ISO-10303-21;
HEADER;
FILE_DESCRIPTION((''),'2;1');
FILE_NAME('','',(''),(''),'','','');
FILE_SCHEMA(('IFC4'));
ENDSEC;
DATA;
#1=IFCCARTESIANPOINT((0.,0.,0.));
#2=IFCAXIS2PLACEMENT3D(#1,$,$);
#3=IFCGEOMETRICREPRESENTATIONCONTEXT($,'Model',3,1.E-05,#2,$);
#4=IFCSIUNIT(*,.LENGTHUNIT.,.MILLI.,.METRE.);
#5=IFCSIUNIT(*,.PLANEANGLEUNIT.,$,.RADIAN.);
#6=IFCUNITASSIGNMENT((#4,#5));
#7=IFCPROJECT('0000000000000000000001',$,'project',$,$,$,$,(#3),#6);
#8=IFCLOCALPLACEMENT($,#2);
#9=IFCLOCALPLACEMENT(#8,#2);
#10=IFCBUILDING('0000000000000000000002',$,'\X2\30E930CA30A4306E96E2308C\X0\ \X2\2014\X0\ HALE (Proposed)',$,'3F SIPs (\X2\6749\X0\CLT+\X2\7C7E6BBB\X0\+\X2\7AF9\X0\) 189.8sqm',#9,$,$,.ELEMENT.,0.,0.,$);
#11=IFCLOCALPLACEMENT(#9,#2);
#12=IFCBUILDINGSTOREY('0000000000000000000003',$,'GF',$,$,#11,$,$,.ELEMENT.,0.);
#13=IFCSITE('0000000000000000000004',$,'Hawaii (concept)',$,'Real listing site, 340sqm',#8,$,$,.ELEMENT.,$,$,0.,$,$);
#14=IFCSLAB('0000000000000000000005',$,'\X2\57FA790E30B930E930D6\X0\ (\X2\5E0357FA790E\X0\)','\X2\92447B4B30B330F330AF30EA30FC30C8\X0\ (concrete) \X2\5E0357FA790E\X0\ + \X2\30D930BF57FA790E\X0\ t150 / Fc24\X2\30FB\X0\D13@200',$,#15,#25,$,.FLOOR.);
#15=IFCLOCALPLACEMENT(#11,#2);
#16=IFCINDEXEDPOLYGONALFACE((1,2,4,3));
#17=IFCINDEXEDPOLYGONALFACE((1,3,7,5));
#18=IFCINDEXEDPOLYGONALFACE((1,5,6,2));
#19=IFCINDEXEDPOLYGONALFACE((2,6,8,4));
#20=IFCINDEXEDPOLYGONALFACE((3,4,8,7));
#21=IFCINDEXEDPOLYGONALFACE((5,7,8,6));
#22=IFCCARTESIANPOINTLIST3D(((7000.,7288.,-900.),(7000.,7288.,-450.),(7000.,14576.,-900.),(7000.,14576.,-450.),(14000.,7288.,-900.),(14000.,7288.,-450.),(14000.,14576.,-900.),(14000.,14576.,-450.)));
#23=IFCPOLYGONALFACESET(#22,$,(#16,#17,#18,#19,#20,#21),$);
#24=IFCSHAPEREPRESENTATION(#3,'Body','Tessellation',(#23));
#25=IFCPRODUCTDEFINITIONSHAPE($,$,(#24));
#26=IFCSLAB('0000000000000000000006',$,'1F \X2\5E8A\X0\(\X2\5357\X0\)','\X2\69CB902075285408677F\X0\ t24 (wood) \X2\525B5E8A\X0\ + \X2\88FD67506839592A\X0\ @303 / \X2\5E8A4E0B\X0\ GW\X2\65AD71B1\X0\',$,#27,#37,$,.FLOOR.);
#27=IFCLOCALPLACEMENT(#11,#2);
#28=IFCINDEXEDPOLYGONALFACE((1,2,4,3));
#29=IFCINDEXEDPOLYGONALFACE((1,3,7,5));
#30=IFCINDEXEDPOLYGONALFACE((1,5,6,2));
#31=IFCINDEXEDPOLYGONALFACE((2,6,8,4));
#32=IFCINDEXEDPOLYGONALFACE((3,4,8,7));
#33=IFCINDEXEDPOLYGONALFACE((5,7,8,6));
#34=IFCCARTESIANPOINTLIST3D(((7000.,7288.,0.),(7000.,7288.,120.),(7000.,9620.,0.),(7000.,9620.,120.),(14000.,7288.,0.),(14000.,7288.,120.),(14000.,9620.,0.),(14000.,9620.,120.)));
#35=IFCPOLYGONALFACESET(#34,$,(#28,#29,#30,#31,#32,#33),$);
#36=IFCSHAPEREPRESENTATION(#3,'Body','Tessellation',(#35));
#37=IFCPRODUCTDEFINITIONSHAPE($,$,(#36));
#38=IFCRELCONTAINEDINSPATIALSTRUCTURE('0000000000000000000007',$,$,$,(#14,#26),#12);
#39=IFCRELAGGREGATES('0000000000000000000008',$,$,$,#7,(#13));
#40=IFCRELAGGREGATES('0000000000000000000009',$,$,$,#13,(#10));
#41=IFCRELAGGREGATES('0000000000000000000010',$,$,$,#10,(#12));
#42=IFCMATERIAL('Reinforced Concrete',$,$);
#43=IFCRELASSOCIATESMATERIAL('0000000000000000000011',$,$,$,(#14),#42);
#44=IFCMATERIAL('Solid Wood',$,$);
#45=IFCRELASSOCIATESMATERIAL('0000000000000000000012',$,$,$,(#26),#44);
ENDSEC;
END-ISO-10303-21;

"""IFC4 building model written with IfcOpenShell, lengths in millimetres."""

from ifc_helpers import new_model, si_unit, frame, frame_2d, origin, place, context, project, spatial, rectangle, extrude, material, element, save


model = new_model("IFC4")

# Units and contexts
model_context = context("Model", 3, precision=1e-05, world=origin())
ifc_project = project(units=[si_unit("LENGTHUNIT", "METRE", prefix="MILLI"), si_unit("PLANEANGLEUNIT", "RADIAN")], contexts=[model_context])

# Site, building, storey
site_placement = place(None, origin())
site = spatial("IfcSite", under=ifc_project, at=site_placement, Name="Hawaii (concept)", ObjectType="Real listing site, 340sqm", CompositionType="ELEMENT", RefElevation=0.0)
building_placement = place(site_placement, origin())
building = spatial("IfcBuilding", under=site, at=building_placement, Name="ラナイの離れ — HALE (Proposed)", ObjectType="3F SIPs (杉CLT+籾殻+竹) 189.8sqm", CompositionType="ELEMENT", ElevationOfRefHeight=0.0, ElevationOfTerrain=0.0)
storey_placement = place(building_placement, origin())
storey = spatial("IfcBuildingStorey", under=building, at=storey_placement, Name="GF", CompositionType="ELEMENT", Elevation=0.0)

# Slabs
ifc_material_1 = material(Name="Reinforced Concrete")
slab_1_placement = place(storey_placement, frame((3500.0, 3644.0, -450.0)))
element("IfcSlab", 1, at=slab_1_placement, inside=storey, material=ifc_material_1, Name="基礎スラブ (布基礎)", Description="鉄筋コンクリート (concrete) 布基礎 + ベタ基礎 t150 / Fc24・D13@200", PredefinedType="FLOOR", context=model_context, shape_type="SweptSolid", body=[
    extrude(rectangle(XDim=7000.0, YDim=7288.0, at=frame_2d((3500.0, 3644.0))), frame((3500.0, 3644.0, -450.0)), (0.0, 0.0, 1.0), 450.0),
])
ifc_material_2 = material(Name="Solid Wood")
slab_2_placement = place(storey_placement, frame((3500.0, 3644.0, 0.0)))
element("IfcSlab", 2, at=slab_2_placement, inside=storey, material=ifc_material_2, Name="1F 床(南)", Description="構造用合板 t24 (wood) 剛床 + 製材根太 @303 / 床下 GW断熱", PredefinedType="FLOOR", context=model_context, shape_type="SweptSolid", body=[
    extrude(rectangle(XDim=7000.0, YDim=2332.0, at=frame_2d((3500.0, 1166.0))), frame((3500.0, 3644.0, 0.0)), (0.0, 0.0, 1.0), 120.0),
])

save(model, "model.ifc")
